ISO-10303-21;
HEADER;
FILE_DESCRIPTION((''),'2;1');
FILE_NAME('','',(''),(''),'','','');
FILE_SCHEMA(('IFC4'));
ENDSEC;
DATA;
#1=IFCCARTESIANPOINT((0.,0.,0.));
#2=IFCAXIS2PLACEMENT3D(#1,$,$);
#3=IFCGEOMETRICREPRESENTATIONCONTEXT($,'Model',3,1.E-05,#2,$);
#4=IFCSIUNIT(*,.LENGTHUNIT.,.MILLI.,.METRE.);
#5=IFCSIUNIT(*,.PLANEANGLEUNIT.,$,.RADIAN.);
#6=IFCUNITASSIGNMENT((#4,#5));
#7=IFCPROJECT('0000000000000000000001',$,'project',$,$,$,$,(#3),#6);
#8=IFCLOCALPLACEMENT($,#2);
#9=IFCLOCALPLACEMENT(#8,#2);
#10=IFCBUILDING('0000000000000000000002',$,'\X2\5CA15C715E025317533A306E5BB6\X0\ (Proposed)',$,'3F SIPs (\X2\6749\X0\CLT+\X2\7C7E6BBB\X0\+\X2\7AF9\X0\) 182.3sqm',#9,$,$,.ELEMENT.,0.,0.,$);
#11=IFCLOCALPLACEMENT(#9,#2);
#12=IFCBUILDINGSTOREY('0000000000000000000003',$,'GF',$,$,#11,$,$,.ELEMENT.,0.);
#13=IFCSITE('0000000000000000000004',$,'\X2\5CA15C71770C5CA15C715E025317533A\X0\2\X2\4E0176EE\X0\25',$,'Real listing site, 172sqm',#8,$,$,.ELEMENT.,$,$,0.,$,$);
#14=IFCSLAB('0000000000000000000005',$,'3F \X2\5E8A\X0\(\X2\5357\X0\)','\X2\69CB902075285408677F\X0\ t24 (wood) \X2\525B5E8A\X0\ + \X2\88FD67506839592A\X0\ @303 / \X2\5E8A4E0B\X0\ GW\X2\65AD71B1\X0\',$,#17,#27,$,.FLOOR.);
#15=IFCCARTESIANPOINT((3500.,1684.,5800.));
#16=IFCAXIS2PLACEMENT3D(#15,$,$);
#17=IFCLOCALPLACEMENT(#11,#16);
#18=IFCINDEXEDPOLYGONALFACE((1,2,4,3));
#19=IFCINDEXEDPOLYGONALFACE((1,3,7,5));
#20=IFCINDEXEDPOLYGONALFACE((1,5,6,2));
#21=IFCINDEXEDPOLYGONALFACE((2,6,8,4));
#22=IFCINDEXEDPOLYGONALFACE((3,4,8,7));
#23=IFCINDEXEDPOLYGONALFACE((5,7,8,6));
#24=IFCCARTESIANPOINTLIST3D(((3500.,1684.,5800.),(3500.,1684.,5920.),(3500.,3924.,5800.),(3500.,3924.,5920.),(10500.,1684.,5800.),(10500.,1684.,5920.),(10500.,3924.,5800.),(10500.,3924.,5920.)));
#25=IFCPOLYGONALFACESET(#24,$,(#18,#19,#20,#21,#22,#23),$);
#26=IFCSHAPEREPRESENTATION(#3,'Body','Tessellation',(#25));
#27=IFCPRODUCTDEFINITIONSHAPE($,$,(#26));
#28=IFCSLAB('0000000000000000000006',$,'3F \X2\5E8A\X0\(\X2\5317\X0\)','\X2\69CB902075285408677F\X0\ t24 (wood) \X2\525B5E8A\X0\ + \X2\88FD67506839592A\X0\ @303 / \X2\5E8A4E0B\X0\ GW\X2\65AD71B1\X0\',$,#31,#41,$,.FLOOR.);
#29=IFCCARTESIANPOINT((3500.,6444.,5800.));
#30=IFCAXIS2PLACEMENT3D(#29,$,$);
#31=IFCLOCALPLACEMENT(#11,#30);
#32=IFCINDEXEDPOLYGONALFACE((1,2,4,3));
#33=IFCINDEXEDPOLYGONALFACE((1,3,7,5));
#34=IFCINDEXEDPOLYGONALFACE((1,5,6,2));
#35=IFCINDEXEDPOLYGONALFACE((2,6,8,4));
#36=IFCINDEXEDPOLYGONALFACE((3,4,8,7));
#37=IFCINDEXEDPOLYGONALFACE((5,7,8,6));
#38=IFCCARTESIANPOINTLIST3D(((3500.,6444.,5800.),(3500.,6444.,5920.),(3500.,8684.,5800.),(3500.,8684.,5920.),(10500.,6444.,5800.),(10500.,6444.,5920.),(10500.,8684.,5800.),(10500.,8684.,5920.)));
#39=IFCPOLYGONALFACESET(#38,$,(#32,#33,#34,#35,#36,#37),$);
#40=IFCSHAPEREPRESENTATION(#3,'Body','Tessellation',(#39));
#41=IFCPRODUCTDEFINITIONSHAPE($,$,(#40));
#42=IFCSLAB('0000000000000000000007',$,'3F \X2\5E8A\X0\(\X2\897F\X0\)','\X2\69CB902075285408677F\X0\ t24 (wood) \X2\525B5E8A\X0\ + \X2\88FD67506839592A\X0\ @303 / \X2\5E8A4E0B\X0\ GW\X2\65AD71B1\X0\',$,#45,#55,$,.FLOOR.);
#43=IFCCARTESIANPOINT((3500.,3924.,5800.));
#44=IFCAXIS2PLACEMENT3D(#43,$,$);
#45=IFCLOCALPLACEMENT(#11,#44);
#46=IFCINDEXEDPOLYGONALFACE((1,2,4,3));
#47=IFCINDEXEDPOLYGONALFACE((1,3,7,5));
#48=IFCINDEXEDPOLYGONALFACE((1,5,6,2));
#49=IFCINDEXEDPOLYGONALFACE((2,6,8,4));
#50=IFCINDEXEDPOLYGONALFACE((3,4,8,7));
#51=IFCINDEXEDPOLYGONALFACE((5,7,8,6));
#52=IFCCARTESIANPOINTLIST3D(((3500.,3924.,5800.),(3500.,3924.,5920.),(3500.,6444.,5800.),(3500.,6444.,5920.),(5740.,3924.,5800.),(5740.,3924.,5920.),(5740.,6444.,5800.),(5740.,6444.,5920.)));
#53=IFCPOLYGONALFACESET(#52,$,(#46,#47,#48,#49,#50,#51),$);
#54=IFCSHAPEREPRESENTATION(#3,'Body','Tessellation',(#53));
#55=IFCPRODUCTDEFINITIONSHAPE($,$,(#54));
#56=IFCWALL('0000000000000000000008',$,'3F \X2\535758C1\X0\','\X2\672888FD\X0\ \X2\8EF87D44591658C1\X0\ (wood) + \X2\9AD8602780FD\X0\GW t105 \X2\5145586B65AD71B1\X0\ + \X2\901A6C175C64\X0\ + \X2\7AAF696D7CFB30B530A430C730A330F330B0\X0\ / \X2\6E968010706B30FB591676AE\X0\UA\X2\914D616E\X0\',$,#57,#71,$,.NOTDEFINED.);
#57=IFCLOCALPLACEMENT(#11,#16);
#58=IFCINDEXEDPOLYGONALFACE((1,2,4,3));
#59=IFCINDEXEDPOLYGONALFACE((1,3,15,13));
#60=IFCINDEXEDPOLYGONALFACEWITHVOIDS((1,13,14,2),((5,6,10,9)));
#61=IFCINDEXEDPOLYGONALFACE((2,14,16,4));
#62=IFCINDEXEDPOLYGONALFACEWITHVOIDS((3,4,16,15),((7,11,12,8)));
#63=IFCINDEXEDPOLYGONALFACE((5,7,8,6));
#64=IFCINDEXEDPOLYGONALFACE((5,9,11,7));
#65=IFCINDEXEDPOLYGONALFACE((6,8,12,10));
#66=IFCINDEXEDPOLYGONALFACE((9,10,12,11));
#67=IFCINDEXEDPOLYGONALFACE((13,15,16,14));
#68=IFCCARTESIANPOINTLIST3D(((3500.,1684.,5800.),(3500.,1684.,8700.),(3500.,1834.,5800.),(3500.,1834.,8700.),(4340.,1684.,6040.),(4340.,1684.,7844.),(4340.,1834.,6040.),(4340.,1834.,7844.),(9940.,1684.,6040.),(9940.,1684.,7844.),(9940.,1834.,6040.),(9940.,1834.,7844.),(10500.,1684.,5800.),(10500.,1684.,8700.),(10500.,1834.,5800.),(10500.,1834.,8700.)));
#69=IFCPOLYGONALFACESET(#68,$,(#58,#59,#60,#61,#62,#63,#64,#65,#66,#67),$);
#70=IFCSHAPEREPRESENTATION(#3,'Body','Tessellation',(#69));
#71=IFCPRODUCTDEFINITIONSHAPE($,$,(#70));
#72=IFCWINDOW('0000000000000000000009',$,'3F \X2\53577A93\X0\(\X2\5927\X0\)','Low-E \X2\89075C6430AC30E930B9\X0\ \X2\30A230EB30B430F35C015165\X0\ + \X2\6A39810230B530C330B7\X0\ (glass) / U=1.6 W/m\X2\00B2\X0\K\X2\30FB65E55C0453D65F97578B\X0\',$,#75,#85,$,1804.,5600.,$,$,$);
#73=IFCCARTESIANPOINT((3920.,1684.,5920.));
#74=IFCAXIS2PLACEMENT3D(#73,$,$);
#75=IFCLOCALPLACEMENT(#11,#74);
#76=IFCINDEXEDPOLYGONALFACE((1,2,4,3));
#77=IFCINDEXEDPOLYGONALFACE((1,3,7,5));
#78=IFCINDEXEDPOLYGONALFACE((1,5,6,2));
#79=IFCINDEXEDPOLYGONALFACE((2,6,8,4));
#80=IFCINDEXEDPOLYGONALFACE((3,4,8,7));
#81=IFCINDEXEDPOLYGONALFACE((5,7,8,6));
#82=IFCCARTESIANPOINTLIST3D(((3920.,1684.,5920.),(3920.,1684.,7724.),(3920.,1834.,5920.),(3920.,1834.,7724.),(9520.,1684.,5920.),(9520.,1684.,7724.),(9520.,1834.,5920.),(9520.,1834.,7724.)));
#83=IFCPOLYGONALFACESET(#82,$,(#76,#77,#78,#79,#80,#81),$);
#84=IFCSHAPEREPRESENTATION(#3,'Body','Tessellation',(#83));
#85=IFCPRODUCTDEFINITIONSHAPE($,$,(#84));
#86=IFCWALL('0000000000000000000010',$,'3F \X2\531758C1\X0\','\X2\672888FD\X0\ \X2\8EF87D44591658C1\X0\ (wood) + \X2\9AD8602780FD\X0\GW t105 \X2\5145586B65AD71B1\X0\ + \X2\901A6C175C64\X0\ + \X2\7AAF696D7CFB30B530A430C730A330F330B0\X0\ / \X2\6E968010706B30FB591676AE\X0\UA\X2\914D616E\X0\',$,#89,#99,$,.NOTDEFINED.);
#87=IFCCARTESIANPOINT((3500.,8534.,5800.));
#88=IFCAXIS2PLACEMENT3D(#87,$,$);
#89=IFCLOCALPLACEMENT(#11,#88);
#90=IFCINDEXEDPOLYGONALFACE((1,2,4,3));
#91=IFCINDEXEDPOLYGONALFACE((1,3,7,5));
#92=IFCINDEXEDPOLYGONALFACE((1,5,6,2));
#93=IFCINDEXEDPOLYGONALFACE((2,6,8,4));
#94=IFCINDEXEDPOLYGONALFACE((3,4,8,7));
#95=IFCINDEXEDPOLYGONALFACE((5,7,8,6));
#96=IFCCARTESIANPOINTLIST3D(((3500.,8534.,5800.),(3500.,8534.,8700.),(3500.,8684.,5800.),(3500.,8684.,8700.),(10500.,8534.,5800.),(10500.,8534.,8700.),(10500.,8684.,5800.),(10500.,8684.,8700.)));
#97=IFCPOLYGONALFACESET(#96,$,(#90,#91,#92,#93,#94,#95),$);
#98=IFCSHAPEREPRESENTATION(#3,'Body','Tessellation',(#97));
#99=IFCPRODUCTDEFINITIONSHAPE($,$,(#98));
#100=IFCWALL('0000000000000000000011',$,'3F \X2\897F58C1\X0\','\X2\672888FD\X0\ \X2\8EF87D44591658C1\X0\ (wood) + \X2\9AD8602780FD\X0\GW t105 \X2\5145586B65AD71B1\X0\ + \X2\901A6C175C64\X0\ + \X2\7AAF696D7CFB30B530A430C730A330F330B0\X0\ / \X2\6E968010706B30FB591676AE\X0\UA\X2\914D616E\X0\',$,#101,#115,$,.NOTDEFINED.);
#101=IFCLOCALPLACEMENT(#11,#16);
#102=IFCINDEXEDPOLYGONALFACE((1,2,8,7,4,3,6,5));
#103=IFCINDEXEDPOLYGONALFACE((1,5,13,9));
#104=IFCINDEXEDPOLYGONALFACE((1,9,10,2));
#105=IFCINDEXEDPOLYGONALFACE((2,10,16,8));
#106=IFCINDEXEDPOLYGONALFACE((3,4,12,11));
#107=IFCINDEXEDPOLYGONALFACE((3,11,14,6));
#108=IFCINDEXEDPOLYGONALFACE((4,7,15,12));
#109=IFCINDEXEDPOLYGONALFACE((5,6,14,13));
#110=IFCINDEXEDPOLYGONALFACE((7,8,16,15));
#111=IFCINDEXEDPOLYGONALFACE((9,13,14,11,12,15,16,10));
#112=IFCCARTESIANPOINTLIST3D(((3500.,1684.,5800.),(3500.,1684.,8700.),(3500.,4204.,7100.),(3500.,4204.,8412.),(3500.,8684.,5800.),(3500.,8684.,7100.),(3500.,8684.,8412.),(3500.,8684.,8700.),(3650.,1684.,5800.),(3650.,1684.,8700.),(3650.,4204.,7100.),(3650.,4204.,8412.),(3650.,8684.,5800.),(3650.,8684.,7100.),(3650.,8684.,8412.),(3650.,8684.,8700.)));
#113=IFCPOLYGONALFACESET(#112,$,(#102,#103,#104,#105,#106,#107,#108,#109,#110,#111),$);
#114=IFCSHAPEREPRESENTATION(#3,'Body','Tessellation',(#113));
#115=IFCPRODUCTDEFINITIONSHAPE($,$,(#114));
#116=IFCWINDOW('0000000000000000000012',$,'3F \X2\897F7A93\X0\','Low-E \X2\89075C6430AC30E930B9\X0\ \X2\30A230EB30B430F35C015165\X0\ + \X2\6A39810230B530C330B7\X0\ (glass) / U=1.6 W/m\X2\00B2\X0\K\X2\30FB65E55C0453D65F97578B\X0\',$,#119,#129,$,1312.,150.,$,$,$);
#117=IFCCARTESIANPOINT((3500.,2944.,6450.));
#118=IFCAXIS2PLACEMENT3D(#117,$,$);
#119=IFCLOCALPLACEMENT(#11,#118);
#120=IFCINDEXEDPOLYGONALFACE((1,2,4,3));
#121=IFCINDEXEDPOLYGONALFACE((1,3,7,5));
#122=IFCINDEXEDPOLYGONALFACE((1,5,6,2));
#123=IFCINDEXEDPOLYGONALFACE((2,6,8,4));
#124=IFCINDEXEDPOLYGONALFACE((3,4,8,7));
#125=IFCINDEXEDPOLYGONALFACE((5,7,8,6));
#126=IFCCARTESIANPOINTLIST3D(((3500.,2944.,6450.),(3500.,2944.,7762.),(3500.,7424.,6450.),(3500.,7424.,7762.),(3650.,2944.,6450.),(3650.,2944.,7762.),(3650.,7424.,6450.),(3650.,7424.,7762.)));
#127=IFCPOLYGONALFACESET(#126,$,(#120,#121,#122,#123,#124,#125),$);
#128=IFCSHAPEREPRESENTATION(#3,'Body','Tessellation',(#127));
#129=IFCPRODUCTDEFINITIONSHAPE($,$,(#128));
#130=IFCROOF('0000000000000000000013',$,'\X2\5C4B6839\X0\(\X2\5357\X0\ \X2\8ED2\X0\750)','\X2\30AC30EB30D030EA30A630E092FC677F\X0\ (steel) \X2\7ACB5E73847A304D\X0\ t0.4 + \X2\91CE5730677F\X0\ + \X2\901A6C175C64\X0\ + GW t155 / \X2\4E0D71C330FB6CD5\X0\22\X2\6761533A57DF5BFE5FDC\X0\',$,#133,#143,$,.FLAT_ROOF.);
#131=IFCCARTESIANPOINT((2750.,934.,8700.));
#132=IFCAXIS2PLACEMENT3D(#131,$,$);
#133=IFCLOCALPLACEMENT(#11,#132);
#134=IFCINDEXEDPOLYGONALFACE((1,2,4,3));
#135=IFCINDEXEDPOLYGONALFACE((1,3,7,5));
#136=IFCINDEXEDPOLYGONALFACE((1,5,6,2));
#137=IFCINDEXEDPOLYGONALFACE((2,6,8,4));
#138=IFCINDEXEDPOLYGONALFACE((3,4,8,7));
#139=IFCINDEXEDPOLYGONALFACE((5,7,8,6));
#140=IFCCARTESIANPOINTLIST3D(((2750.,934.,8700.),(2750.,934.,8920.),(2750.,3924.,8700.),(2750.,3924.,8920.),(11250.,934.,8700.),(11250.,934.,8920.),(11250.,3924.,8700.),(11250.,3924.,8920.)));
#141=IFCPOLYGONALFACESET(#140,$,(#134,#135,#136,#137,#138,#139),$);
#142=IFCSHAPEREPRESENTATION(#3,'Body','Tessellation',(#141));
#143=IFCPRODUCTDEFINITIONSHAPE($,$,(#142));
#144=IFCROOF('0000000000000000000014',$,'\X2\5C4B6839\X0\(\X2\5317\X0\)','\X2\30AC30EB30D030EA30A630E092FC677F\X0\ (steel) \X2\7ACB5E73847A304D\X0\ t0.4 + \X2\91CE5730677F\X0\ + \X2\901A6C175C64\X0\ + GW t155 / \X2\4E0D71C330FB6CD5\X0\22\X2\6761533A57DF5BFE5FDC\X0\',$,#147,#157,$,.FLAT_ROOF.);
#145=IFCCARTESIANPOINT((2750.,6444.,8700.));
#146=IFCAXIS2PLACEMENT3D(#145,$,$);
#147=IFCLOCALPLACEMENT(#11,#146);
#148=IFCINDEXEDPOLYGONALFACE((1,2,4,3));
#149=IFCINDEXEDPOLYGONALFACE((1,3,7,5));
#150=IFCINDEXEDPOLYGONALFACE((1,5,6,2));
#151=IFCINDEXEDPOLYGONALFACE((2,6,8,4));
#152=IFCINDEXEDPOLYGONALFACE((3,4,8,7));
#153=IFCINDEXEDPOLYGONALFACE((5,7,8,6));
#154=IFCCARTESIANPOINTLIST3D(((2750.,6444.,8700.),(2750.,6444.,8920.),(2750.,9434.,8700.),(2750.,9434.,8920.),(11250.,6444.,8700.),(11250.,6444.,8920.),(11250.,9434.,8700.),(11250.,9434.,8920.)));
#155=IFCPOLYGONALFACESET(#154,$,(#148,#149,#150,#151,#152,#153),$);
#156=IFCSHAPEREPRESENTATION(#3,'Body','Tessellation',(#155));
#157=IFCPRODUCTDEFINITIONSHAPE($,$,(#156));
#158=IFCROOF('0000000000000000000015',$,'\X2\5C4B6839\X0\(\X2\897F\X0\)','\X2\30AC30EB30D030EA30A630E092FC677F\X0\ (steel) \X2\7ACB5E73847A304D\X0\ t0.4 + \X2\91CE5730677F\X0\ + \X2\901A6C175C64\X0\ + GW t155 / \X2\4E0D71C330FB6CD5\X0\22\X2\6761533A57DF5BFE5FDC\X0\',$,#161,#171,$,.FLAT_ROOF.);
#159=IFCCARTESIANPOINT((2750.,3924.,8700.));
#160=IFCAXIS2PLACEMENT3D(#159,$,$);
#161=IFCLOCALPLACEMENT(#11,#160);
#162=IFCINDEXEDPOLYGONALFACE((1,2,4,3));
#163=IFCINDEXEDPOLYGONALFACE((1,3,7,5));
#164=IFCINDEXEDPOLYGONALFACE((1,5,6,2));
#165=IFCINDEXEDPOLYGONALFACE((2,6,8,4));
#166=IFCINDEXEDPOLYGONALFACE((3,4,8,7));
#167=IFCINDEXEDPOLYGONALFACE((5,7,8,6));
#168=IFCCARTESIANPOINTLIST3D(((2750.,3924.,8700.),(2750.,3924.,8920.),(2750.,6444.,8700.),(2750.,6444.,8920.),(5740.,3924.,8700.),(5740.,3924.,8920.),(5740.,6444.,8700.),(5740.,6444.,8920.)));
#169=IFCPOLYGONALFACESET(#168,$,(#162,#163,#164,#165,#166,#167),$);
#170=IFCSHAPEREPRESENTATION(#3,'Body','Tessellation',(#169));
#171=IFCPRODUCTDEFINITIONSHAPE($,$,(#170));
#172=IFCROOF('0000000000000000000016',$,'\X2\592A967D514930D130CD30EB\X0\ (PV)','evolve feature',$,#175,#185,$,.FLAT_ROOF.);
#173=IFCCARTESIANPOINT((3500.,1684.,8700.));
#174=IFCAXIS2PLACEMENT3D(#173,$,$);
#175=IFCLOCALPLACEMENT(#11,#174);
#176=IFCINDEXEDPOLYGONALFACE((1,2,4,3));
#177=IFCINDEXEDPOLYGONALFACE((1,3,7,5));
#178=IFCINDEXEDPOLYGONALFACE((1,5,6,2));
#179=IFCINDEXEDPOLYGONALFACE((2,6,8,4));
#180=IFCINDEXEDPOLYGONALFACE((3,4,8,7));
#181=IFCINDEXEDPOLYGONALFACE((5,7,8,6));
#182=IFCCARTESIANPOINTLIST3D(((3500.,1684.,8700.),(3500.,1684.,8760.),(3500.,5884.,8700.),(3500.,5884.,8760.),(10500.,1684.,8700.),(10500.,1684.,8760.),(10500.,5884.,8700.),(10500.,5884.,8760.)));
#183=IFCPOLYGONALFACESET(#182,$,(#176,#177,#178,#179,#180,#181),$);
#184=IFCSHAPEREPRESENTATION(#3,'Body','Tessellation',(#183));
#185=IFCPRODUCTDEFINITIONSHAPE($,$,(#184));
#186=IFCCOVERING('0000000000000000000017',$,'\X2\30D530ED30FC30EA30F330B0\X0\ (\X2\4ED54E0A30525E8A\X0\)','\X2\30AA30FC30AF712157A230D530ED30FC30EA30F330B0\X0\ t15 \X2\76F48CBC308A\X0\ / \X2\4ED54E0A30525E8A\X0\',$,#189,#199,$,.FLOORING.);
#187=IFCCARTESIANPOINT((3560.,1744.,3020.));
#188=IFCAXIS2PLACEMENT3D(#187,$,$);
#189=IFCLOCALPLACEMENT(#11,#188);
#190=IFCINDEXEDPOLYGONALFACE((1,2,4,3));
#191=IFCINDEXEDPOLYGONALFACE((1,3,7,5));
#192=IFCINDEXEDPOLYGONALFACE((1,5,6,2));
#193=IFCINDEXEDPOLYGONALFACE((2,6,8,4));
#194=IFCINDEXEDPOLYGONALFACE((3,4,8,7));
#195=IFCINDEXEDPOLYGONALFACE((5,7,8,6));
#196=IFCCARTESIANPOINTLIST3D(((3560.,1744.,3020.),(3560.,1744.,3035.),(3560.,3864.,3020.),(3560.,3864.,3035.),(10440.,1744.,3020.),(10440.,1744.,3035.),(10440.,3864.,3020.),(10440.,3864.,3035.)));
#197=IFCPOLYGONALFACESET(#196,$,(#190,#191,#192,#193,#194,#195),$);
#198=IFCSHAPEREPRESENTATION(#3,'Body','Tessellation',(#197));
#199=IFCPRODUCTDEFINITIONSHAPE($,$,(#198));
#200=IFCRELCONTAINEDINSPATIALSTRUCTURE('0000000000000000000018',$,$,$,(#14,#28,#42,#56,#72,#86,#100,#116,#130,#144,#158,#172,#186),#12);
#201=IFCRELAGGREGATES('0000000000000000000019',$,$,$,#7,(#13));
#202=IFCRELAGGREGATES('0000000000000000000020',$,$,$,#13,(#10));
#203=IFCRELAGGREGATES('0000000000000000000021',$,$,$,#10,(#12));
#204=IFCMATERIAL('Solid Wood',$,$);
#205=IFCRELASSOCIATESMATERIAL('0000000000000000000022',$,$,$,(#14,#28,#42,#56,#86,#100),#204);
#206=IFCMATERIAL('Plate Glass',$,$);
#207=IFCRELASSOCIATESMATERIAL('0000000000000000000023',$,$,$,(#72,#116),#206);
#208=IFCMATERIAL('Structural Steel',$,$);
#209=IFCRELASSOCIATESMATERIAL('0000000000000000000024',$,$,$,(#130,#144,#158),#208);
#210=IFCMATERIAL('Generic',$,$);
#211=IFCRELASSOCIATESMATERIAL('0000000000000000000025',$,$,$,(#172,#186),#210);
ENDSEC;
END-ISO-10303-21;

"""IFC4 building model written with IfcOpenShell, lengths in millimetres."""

from ifc_helpers import new_model, si_unit, frame, frame_2d, origin, place, context, project, spatial, rectangle, extrude, material, element, fill, save


model = new_model("IFC4")

# Units and contexts
model_context = context("Model", 3, precision=1e-05, world=origin())
ifc_project = project(units=[si_unit("LENGTHUNIT", "METRE", prefix="MILLI"), si_unit("PLANEANGLEUNIT", "RADIAN")], contexts=[model_context])

# Site, building, storey
site_placement = place(None, origin())
site = spatial("IfcSite", under=ifc_project, at=site_placement, Name="岡山県岡山市北区2丁目25", ObjectType="Real listing site, 172sqm", CompositionType="ELEMENT", RefElevation=0.0)
building_placement = place(site_placement, origin())
building = spatial("IfcBuilding", under=site, at=building_placement, Name="岡山市北区の家 (Proposed)", ObjectType="3F SIPs (杉CLT+籾殻+竹) 182.3sqm", CompositionType="ELEMENT", ElevationOfRefHeight=0.0, ElevationOfTerrain=0.0)
storey_placement = place(building_placement, origin())
storey = spatial("IfcBuildingStorey", under=building, at=storey_placement, Name="GF", CompositionType="ELEMENT", Elevation=0.0)

# Slabs
ifc_material_1 = material(Name="Solid Wood")
slab_1_placement = place(storey_placement, frame((3500.0, 1684.0, 5800.0)))
element("IfcSlab", 1, at=slab_1_placement, inside=storey, material=ifc_material_1, Name="3F 床(南)", Description="構造用合板 t24 (wood) 剛床 + 製材根太 @303 / 床下 GW断熱", PredefinedType="FLOOR", context=model_context, shape_type="SweptSolid", body=[
    extrude(rectangle(XDim=7000.0, YDim=2240.0, at=frame_2d((3500.0, 1120.0))), frame((3500.0, 1684.0, 5800.0)), (0.0, 0.0, 1.0), 120.0),
])
slab_2_placement = place(storey_placement, frame((3500.0, 6444.0, 5800.0)))
element("IfcSlab", 2, at=slab_2_placement, inside=storey, material=ifc_material_1, Name="3F 床(北)", Description="構造用合板 t24 (wood) 剛床 + 製材根太 @303 / 床下 GW断熱", PredefinedType="FLOOR", context=model_context, shape_type="SweptSolid", body=[
    extrude(rectangle(XDim=7000.0, YDim=2240.0, at=frame_2d((3500.0, 1120.0))), frame((3500.0, 6444.0, 5800.0)), (0.0, 0.0, 1.0), 120.0),
])
slab_3_placement = place(storey_placement, frame((3500.0, 3924.0, 5800.0)))
element("IfcSlab", 3, at=slab_3_placement, inside=storey, material=ifc_material_1, Name="3F 床(西)", Description="構造用合板 t24 (wood) 剛床 + 製材根太 @303 / 床下 GW断熱", PredefinedType="FLOOR", context=model_context, shape_type="SweptSolid", body=[
    extrude(rectangle(XDim=2240.0, YDim=2520.0, at=frame_2d((1120.0, 1260.0))), frame((3500.0, 3924.0, 5800.0)), (0.0, 0.0, 1.0), 120.0),
])

# Wall, opening, window
wall_1_placement = place(storey_placement, frame((3500.0, 1684.0, 5800.0)))
wall_1 = element("IfcWall", 4, at=wall_1_placement, inside=storey, material=ifc_material_1, Name="3F 南壁", Description="木製 軸組外壁 (wood) + 高性能GW t105 充填断熱 + 通気層 + 窯業系サイディング / 準耐火・外皮UA配慮", PredefinedType="NOTDEFINED", context=model_context, shape_type="SweptSolid", body=[
    extrude(rectangle(XDim=7000.0, YDim=150.0, at=frame_2d((3500.0, 75.0))), frame((3500.0, 1684.0, 5800.0)), (0.0, 0.0, 1.0), 2900.0),
])
opening_1_placement = place(storey_placement, frame((3920.0, 1684.0, 5920.0)))
opening_1 = element("IfcOpeningElement", 5, at=opening_1_placement, cuts=wall_1, PredefinedType="NOTDEFINED", context=model_context, shape_type="SweptSolid", body=[
    extrude(rectangle(XDim=5600.0, YDim=150.0, at=frame_2d((2800.0, 75.0))), frame((3920.0, 1684.0, 5920.0)), (0.0, 0.0, 1.0), 1804.0),
])
ifc_material_2 = material(Name="Plate Glass")
window_1_placement = place(storey_placement, frame((3920.0, 1684.0, 5920.0)))
window_1 = element("IfcWindow", 6, at=window_1_placement, inside=storey, material=ifc_material_2, Name="3F 南窓(大)", Description="Low-E 複層ガラス アルゴン封入 + 樹脂サッシ (glass) / U=1.6 W/m²K・日射取得型", OverallHeight=1804.0, OverallWidth=5600.0, context=model_context, shape_type="SweptSolid", body=[
    extrude(rectangle(XDim=5600.0, YDim=150.0, at=frame_2d((2800.0, 75.0))), frame((3920.0, 1684.0, 5920.0)), (0.0, 0.0, 1.0), 1804.0),
])
fill(opening_1, window_1)

# Wall
wall_2_placement = place(storey_placement, frame((3500.0, 8534.0, 5800.0)))
element("IfcWall", 7, at=wall_2_placement, inside=storey, material=ifc_material_1, Name="3F 北壁", Description="木製 軸組外壁 (wood) + 高性能GW t105 充填断熱 + 通気層 + 窯業系サイディング / 準耐火・外皮UA配慮", PredefinedType="NOTDEFINED", context=model_context, shape_type="SweptSolid", body=[
    extrude(rectangle(XDim=7000.0, YDim=150.0, at=frame_2d((3500.0, 75.0))), frame((3500.0, 8534.0, 5800.0)), (0.0, 0.0, 1.0), 2900.0),
])

# Wall, opening, window
wall_3_placement = place(storey_placement, frame((3500.0, 1684.0, 5800.0)))
wall_3 = element("IfcWall", 8, at=wall_3_placement, inside=storey, material=ifc_material_1, Name="3F 西壁", Description="木製 軸組外壁 (wood) + 高性能GW t105 充填断熱 + 通気層 + 窯業系サイディング / 準耐火・外皮UA配慮", PredefinedType="NOTDEFINED", context=model_context, shape_type="SweptSolid", body=[
    extrude(rectangle(XDim=150.0, YDim=7000.0, at=frame_2d((75.0, 3500.0))), frame((3500.0, 1684.0, 5800.0)), (0.0, 0.0, 1.0), 2900.0),
])
opening_2_placement = place(storey_placement, frame((3500.0, 2944.0, 6450.0)))
opening_2 = element("IfcOpeningElement", 9, at=opening_2_placement, cuts=wall_3, PredefinedType="NOTDEFINED", context=model_context, shape_type="SweptSolid", body=[
    extrude(rectangle(XDim=150.0, YDim=4480.0, at=frame_2d((75.0, 2240.0))), frame((3500.0, 2944.0, 6450.0)), (0.0, 0.0, 1.0), 1312.0),
])
window_2_placement = place(storey_placement, frame((3500.0, 2944.0, 6450.0)))
window_2 = element("IfcWindow", 10, at=window_2_placement, inside=storey, material=ifc_material_2, Name="3F 西窓", Description="Low-E 複層ガラス アルゴン封入 + 樹脂サッシ (glass) / U=1.6 W/m²K・日射取得型", OverallHeight=1312.0, OverallWidth=150.0, context=model_context, shape_type="SweptSolid", body=[
    extrude(rectangle(XDim=150.0, YDim=4480.0, at=frame_2d((75.0, 2240.0))), frame((3500.0, 2944.0, 6450.0)), (0.0, 0.0, 1.0), 1312.0),
])
fill(opening_2, window_2)

# Roofs
ifc_material_3 = material(Name="Structural Steel")
roof_1_placement = place(storey_placement, frame((2750.0, 934.0, 8700.0)))
element("IfcRoof", 11, at=roof_1_placement, inside=storey, material=ifc_material_3, Name="屋根(南 軒750)", Description="ガルバリウム鋼板 (steel) 立平葺き t0.4 + 野地板 + 通気層 + GW t155 / 不燃・法22条区域対応", PredefinedType="FLAT_ROOF", context=model_context, shape_type="SweptSolid", body=[
    extrude(rectangle(XDim=8500.0, YDim=2990.0, at=frame_2d((4250.0, 1495.0))), frame((2750.0, 934.0, 8700.0)), (0.0, 0.0, 1.0), 220.0),
])
roof_2_placement = place(storey_placement, frame((2750.0, 6444.0, 8700.0)))
element("IfcRoof", 12, at=roof_2_placement, inside=storey, material=ifc_material_3, Name="屋根(北)", Description="ガルバリウム鋼板 (steel) 立平葺き t0.4 + 野地板 + 通気層 + GW t155 / 不燃・法22条区域対応", PredefinedType="FLAT_ROOF", context=model_context, shape_type="SweptSolid", body=[
    extrude(rectangle(XDim=8500.0, YDim=2990.0, at=frame_2d((4250.0, 1495.0))), frame((2750.0, 6444.0, 8700.0)), (0.0, 0.0, 1.0), 220.0),
])
roof_3_placement = place(storey_placement, frame((2750.0, 3924.0, 8700.0)))
element("IfcRoof", 13, at=roof_3_placement, inside=storey, material=ifc_material_3, Name="屋根(西)", Description="ガルバリウム鋼板 (steel) 立平葺き t0.4 + 野地板 + 通気層 + GW t155 / 不燃・法22条区域対応", PredefinedType="FLAT_ROOF", context=model_context, shape_type="SweptSolid", body=[
    extrude(rectangle(XDim=2990.0, YDim=2520.0, at=frame_2d((1495.0, 1260.0))), frame((2750.0, 3924.0, 8700.0)), (0.0, 0.0, 1.0), 220.0),
])
ifc_material_4 = material(Name="Generic")
roof_4_placement = place(storey_placement, frame((3500.0, 1684.0, 8700.0)))
element("IfcRoof", 14, at=roof_4_placement, inside=storey, material=ifc_material_4, Name="太陽光パネル (PV)", Description="evolve feature", PredefinedType="FLAT_ROOF", context=model_context, shape_type="SweptSolid", body=[
    extrude(rectangle(XDim=7000.0, YDim=4200.0, at=frame_2d((3500.0, 2100.0))), frame((3500.0, 1684.0, 8700.0)), (0.0, 0.0, 1.0), 60.0),
])

# Covering
covering_1_placement = place(storey_placement, frame((3560.0, 1744.0, 3020.0)))
element("IfcCovering", 15, at=covering_1_placement, inside=storey, material=ifc_material_4, Name="フローリング (仕上げ床)", Description="オーク無垢フローリング t15 直貼り / 仕上げ床", PredefinedType="FLOORING", context=model_context, shape_type="SweptSolid", body=[
    extrude(rectangle(XDim=6880.0, YDim=2120.0, at=frame_2d((3440.0, 1060.0))), frame((3560.0, 1744.0, 3020.0)), (0.0, 0.0, 1.0), 15.0),
])

save(model, "model.ifc")
